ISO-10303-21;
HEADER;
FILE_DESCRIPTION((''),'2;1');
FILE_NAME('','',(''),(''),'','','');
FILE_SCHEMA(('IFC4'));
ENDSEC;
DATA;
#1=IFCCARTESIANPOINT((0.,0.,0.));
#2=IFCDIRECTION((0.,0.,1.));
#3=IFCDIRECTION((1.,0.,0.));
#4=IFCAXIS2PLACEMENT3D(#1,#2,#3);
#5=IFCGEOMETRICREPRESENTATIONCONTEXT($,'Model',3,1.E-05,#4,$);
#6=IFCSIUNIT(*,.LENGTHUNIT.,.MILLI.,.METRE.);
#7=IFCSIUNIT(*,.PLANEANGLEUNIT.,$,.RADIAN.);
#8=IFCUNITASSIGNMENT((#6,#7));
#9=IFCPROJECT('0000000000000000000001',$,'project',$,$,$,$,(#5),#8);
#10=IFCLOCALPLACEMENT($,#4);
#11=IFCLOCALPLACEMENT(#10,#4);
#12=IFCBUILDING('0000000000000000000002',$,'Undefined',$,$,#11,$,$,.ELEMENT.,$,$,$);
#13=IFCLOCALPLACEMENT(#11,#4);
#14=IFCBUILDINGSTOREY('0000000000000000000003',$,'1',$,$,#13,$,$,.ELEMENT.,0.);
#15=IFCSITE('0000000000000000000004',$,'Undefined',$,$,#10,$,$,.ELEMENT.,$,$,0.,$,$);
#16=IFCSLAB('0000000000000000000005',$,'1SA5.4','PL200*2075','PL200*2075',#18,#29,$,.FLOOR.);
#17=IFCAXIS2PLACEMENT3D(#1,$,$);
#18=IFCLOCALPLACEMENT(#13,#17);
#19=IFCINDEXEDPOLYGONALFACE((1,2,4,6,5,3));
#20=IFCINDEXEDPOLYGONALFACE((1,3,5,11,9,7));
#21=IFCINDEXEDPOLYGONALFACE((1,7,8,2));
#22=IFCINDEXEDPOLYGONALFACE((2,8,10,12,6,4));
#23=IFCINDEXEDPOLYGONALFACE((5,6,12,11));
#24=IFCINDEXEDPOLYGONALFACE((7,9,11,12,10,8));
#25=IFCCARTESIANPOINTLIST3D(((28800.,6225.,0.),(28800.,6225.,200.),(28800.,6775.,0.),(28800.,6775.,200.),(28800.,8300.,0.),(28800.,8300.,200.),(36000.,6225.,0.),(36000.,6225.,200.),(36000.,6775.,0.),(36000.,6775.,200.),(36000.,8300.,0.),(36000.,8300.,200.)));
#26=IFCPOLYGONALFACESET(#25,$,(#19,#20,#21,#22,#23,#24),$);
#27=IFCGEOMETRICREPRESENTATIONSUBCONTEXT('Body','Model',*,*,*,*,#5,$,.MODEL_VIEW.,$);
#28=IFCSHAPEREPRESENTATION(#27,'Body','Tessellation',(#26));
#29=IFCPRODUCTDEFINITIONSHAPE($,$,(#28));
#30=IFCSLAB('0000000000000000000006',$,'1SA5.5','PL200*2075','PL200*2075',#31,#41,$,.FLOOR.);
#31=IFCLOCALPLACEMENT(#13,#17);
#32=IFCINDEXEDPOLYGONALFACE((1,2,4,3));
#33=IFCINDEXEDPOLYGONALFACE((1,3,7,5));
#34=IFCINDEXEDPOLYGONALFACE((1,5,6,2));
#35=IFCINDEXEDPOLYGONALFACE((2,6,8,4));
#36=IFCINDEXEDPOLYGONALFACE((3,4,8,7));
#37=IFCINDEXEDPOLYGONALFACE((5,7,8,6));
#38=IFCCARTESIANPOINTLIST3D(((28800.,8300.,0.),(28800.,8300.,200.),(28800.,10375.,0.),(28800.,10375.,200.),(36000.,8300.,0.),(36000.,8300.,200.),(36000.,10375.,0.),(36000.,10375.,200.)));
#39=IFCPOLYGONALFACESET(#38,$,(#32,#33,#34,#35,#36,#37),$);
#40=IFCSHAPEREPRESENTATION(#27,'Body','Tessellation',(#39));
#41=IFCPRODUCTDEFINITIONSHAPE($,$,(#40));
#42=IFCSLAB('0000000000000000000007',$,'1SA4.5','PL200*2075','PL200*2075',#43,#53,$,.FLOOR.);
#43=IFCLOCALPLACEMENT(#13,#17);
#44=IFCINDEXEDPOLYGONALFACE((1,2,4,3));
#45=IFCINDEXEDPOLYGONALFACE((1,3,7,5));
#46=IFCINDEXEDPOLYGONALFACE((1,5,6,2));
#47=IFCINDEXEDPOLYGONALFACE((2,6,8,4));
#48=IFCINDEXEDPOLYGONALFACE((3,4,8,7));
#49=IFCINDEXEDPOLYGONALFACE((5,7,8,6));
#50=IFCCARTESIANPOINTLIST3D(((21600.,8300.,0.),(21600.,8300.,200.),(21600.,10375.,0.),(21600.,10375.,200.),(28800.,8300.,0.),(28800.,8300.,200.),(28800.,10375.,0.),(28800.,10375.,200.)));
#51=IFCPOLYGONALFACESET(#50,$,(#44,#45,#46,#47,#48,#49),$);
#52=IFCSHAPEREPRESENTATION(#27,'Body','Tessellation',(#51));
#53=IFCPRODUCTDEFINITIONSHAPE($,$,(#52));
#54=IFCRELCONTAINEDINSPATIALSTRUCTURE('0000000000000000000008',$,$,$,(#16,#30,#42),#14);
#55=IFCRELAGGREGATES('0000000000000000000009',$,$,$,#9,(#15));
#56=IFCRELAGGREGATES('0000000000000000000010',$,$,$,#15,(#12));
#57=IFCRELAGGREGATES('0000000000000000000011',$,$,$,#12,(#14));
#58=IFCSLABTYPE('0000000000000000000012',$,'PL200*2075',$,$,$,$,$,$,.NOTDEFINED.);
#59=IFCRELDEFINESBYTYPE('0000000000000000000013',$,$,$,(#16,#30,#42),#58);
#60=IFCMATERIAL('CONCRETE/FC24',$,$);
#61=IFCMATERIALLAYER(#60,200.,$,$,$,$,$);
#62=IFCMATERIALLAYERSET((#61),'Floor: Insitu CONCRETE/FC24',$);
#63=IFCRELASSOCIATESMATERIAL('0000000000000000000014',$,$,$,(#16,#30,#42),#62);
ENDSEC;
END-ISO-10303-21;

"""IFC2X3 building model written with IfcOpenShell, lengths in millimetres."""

from ifc_helpers import new_model, si_unit, frame, origin_with_axes, place, context, subcontext, project, spatial, polyline, outline, extrude, material, layer, layer_set, layer_usage, type_object, element, save


model = new_model("IFC2X3")

# Units and contexts
model_context = context("Model", 3, precision=1e-05, world=origin_with_axes())
body_context = subcontext(model_context, "Body", "Model", "MODEL_VIEW")
ifc_project = project(units=[si_unit("LENGTHUNIT", "METRE", prefix="MILLI"), si_unit("PLANEANGLEUNIT", "RADIAN")], contexts=[model_context])

# Site, building, storey
site_placement = place(None, origin_with_axes())
site = spatial("IfcSite", under=ifc_project, at=site_placement, Name="Undefined", CompositionType="ELEMENT", RefElevation=0.0)
building_placement = place(site_placement, origin_with_axes())
building = spatial("IfcBuilding", under=site, at=building_placement, Name="Undefined", CompositionType="ELEMENT")
storey_placement = place(building_placement, origin_with_axes())
storey = spatial("IfcBuildingStorey", under=building, at=storey_placement, Name="1", CompositionType="ELEMENT", Elevation=0.0)

# Shared definitions
ifc_material_1 = material(Name="CONCRETE/FC24")

# Slabs
ifc_layer = layer(ifc_material_1, 200.0)
ifc_layer_set = layer_set([ifc_layer], Name="Floor: Insitu CONCRETE/FC24")
slab_type = type_object("IfcSlabType", Name="PL200*2075", PredefinedType="NOTDEFINED")
ifc_layer_usage_1 = layer_usage(ifc_layer_set, "AXIS3", "POSITIVE", -100.0)
slab_1_placement = place(storey_placement, frame((28800.0, 6225.0, 100.0), z_axis=(0.0, 0.0, 1.0), x_axis=(1.0, 0.0, 0.0)))
element("IfcSlab", 1, at=slab_1_placement, inside=storey, type_object=slab_type, material=ifc_layer_usage_1, Name="1SA5.4", Description="PL200*2075", ObjectType="PL200*2075", PredefinedType="FLOOR", context=body_context, shape_type="SweptSolid", body=[
    extrude(outline(polyline([(0.0, 0.0), (7200.0, 0.0), (7200.0, 550.0), (7200.0, 2075.0), (0.0, 2075.0), (0.0, 550.0), (0.0, 0.0)])), frame((0.0, 0.0, -100.0), z_axis=(0.0, 0.0, 1.0), x_axis=(1.0, 0.0, 0.0)), (0.0, 0.0, 1.0), 200.0),
])
ifc_layer_usage_2 = layer_usage(ifc_layer_set, "AXIS3", "POSITIVE", -100.0)
slab_2_placement = place(storey_placement, frame((28800.0, 8300.0, 100.0), z_axis=(0.0, 0.0, 1.0), x_axis=(1.0, 0.0, 0.0)))
element("IfcSlab", 2, at=slab_2_placement, inside=storey, type_object=slab_type, material=ifc_layer_usage_2, Name="1SA5.5", Description="PL200*2075", ObjectType="PL200*2075", PredefinedType="FLOOR", context=body_context, shape_type="SweptSolid", body=[
    extrude(outline(polyline([(0.0, 0.0), (7200.0, 0.0), (7200.0, 2075.0), (0.0, 2075.0), (0.0, 0.0)])), frame((0.0, 0.0, -100.0), z_axis=(0.0, 0.0, 1.0), x_axis=(1.0, 0.0, 0.0)), (0.0, 0.0, 1.0), 200.0),
])
ifc_layer_usage_3 = layer_usage(ifc_layer_set, "AXIS3", "POSITIVE", -100.0)
slab_3_placement = place(storey_placement, frame((21600.0, 8300.0, 100.0), z_axis=(0.0, 0.0, 1.0), x_axis=(1.0, 0.0, 0.0)))
element("IfcSlab", 3, at=slab_3_placement, inside=storey, type_object=slab_type, material=ifc_layer_usage_3, Name="1SA4.5", Description="PL200*2075", ObjectType="PL200*2075", PredefinedType="FLOOR", context=body_context, shape_type="SweptSolid", body=[
    extrude(outline(polyline([(0.0, 0.0), (7200.0, 0.0), (7200.0, 2075.0), (0.0, 2075.0), (0.0, 0.0)])), frame((0.0, 0.0, -100.0), z_axis=(0.0, 0.0, 1.0), x_axis=(1.0, 0.0, 0.0)), (0.0, 0.0, 1.0), 200.0),
])

save(model, "model.ifc")
